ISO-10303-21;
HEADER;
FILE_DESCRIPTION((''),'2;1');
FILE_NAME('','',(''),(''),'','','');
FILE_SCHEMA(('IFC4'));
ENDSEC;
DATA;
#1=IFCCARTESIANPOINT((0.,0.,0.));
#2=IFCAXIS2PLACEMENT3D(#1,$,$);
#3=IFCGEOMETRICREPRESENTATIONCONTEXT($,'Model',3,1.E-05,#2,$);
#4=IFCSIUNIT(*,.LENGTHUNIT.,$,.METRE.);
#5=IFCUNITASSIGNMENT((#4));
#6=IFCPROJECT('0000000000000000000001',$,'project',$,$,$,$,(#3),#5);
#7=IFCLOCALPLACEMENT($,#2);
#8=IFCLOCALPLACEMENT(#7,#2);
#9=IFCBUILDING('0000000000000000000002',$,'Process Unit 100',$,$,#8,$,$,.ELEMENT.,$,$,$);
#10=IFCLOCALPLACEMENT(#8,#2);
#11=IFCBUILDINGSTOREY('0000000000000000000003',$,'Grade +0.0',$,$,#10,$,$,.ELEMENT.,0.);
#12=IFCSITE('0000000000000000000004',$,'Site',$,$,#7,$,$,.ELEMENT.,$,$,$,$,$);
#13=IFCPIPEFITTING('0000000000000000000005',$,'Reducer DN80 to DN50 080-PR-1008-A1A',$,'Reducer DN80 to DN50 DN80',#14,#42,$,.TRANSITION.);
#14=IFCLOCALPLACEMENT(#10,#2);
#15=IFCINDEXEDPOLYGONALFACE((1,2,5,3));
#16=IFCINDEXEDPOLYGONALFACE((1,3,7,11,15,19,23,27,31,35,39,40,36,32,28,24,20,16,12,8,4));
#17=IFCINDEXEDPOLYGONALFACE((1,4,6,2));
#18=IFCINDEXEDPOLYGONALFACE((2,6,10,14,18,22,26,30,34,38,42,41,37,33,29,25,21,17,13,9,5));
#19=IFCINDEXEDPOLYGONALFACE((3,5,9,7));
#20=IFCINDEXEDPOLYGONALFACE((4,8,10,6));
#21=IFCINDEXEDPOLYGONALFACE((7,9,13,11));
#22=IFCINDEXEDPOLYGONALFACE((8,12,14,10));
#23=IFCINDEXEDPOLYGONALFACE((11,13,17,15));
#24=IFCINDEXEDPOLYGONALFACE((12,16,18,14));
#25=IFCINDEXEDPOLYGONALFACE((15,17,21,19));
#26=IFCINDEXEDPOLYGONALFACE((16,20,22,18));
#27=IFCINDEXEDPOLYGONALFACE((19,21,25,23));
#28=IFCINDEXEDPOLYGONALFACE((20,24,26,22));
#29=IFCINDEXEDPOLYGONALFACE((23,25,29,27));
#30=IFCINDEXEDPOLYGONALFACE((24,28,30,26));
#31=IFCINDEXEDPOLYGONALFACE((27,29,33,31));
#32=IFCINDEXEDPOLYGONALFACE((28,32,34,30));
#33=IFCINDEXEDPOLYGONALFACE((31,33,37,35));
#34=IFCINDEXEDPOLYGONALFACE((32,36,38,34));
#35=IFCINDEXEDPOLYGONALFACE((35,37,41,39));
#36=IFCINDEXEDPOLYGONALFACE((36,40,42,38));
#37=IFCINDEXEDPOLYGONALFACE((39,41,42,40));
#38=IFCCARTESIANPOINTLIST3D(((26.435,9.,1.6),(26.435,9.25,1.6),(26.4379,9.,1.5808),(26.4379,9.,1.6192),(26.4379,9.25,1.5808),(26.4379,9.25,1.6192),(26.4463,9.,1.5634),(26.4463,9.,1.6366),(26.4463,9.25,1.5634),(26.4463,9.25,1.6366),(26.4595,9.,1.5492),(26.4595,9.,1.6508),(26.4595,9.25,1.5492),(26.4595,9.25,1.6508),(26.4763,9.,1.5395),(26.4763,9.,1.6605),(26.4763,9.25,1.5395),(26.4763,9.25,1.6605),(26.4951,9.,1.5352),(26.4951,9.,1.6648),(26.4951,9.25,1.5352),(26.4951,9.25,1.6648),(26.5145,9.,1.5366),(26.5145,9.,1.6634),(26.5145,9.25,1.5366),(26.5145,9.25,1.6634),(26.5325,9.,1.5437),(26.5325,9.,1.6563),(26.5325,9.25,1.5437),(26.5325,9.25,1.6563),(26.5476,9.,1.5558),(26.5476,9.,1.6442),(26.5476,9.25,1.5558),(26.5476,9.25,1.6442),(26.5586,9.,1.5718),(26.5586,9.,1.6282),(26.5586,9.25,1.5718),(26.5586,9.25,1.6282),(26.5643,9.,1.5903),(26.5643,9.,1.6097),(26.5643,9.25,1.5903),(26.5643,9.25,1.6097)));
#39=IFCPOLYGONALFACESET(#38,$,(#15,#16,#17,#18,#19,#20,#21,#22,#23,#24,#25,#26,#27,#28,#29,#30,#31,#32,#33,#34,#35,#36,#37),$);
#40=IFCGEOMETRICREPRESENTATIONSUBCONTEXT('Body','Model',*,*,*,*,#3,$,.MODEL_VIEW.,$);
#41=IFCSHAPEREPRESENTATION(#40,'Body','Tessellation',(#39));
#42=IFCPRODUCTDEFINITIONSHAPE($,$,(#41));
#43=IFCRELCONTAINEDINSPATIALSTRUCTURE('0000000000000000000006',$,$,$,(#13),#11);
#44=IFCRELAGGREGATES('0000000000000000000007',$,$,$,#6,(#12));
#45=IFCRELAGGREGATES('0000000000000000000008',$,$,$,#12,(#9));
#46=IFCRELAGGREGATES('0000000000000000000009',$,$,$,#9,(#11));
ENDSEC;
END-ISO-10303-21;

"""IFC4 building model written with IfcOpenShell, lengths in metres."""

from ifc_helpers import new_model, si_unit, frame, origin, place, context, subcontext, project, spatial, circle, extrude, element, save


model = new_model("IFC4")

# Units and contexts
model_context = context("Model", 3, precision=1e-05, world=origin())
body_context = subcontext(model_context, "Body", "Model", "MODEL_VIEW")
ifc_project = project(units=[si_unit("LENGTHUNIT", "METRE")], contexts=[model_context])

# Site, building, storey
site_placement = place(None, origin())
site = spatial("IfcSite", under=ifc_project, at=site_placement, Name="Site", CompositionType="ELEMENT")
building_placement = place(site_placement, origin())
building = spatial("IfcBuilding", under=site, at=building_placement, Name="Process Unit 100", CompositionType="ELEMENT")
storey_placement = place(building_placement, origin())
storey = spatial("IfcBuildingStorey", under=building, at=storey_placement, Name="Grade +0.0", CompositionType="ELEMENT", Elevation=0.0)

# Pipe fitting
pipe_fitting_1_placement = place(storey_placement, frame((26.5, 9.0, 1.6), z_axis=(0.0, 1.0, 0.0), x_axis=(-1.0, 0.0, 0.0)))
element("IfcPipeFitting", 1, at=pipe_fitting_1_placement, inside=storey, Name="Reducer DN80 to DN50 080-PR-1008-A1A", ObjectType="Reducer DN80 to DN50 DN80", PredefinedType="TRANSITION", context=body_context, shape_type="SweptSolid", body=[
    extrude(circle(Radius=0.065), origin(), (0.0, 0.0, 1.0), 0.25),
])

save(model, "model.ifc")
